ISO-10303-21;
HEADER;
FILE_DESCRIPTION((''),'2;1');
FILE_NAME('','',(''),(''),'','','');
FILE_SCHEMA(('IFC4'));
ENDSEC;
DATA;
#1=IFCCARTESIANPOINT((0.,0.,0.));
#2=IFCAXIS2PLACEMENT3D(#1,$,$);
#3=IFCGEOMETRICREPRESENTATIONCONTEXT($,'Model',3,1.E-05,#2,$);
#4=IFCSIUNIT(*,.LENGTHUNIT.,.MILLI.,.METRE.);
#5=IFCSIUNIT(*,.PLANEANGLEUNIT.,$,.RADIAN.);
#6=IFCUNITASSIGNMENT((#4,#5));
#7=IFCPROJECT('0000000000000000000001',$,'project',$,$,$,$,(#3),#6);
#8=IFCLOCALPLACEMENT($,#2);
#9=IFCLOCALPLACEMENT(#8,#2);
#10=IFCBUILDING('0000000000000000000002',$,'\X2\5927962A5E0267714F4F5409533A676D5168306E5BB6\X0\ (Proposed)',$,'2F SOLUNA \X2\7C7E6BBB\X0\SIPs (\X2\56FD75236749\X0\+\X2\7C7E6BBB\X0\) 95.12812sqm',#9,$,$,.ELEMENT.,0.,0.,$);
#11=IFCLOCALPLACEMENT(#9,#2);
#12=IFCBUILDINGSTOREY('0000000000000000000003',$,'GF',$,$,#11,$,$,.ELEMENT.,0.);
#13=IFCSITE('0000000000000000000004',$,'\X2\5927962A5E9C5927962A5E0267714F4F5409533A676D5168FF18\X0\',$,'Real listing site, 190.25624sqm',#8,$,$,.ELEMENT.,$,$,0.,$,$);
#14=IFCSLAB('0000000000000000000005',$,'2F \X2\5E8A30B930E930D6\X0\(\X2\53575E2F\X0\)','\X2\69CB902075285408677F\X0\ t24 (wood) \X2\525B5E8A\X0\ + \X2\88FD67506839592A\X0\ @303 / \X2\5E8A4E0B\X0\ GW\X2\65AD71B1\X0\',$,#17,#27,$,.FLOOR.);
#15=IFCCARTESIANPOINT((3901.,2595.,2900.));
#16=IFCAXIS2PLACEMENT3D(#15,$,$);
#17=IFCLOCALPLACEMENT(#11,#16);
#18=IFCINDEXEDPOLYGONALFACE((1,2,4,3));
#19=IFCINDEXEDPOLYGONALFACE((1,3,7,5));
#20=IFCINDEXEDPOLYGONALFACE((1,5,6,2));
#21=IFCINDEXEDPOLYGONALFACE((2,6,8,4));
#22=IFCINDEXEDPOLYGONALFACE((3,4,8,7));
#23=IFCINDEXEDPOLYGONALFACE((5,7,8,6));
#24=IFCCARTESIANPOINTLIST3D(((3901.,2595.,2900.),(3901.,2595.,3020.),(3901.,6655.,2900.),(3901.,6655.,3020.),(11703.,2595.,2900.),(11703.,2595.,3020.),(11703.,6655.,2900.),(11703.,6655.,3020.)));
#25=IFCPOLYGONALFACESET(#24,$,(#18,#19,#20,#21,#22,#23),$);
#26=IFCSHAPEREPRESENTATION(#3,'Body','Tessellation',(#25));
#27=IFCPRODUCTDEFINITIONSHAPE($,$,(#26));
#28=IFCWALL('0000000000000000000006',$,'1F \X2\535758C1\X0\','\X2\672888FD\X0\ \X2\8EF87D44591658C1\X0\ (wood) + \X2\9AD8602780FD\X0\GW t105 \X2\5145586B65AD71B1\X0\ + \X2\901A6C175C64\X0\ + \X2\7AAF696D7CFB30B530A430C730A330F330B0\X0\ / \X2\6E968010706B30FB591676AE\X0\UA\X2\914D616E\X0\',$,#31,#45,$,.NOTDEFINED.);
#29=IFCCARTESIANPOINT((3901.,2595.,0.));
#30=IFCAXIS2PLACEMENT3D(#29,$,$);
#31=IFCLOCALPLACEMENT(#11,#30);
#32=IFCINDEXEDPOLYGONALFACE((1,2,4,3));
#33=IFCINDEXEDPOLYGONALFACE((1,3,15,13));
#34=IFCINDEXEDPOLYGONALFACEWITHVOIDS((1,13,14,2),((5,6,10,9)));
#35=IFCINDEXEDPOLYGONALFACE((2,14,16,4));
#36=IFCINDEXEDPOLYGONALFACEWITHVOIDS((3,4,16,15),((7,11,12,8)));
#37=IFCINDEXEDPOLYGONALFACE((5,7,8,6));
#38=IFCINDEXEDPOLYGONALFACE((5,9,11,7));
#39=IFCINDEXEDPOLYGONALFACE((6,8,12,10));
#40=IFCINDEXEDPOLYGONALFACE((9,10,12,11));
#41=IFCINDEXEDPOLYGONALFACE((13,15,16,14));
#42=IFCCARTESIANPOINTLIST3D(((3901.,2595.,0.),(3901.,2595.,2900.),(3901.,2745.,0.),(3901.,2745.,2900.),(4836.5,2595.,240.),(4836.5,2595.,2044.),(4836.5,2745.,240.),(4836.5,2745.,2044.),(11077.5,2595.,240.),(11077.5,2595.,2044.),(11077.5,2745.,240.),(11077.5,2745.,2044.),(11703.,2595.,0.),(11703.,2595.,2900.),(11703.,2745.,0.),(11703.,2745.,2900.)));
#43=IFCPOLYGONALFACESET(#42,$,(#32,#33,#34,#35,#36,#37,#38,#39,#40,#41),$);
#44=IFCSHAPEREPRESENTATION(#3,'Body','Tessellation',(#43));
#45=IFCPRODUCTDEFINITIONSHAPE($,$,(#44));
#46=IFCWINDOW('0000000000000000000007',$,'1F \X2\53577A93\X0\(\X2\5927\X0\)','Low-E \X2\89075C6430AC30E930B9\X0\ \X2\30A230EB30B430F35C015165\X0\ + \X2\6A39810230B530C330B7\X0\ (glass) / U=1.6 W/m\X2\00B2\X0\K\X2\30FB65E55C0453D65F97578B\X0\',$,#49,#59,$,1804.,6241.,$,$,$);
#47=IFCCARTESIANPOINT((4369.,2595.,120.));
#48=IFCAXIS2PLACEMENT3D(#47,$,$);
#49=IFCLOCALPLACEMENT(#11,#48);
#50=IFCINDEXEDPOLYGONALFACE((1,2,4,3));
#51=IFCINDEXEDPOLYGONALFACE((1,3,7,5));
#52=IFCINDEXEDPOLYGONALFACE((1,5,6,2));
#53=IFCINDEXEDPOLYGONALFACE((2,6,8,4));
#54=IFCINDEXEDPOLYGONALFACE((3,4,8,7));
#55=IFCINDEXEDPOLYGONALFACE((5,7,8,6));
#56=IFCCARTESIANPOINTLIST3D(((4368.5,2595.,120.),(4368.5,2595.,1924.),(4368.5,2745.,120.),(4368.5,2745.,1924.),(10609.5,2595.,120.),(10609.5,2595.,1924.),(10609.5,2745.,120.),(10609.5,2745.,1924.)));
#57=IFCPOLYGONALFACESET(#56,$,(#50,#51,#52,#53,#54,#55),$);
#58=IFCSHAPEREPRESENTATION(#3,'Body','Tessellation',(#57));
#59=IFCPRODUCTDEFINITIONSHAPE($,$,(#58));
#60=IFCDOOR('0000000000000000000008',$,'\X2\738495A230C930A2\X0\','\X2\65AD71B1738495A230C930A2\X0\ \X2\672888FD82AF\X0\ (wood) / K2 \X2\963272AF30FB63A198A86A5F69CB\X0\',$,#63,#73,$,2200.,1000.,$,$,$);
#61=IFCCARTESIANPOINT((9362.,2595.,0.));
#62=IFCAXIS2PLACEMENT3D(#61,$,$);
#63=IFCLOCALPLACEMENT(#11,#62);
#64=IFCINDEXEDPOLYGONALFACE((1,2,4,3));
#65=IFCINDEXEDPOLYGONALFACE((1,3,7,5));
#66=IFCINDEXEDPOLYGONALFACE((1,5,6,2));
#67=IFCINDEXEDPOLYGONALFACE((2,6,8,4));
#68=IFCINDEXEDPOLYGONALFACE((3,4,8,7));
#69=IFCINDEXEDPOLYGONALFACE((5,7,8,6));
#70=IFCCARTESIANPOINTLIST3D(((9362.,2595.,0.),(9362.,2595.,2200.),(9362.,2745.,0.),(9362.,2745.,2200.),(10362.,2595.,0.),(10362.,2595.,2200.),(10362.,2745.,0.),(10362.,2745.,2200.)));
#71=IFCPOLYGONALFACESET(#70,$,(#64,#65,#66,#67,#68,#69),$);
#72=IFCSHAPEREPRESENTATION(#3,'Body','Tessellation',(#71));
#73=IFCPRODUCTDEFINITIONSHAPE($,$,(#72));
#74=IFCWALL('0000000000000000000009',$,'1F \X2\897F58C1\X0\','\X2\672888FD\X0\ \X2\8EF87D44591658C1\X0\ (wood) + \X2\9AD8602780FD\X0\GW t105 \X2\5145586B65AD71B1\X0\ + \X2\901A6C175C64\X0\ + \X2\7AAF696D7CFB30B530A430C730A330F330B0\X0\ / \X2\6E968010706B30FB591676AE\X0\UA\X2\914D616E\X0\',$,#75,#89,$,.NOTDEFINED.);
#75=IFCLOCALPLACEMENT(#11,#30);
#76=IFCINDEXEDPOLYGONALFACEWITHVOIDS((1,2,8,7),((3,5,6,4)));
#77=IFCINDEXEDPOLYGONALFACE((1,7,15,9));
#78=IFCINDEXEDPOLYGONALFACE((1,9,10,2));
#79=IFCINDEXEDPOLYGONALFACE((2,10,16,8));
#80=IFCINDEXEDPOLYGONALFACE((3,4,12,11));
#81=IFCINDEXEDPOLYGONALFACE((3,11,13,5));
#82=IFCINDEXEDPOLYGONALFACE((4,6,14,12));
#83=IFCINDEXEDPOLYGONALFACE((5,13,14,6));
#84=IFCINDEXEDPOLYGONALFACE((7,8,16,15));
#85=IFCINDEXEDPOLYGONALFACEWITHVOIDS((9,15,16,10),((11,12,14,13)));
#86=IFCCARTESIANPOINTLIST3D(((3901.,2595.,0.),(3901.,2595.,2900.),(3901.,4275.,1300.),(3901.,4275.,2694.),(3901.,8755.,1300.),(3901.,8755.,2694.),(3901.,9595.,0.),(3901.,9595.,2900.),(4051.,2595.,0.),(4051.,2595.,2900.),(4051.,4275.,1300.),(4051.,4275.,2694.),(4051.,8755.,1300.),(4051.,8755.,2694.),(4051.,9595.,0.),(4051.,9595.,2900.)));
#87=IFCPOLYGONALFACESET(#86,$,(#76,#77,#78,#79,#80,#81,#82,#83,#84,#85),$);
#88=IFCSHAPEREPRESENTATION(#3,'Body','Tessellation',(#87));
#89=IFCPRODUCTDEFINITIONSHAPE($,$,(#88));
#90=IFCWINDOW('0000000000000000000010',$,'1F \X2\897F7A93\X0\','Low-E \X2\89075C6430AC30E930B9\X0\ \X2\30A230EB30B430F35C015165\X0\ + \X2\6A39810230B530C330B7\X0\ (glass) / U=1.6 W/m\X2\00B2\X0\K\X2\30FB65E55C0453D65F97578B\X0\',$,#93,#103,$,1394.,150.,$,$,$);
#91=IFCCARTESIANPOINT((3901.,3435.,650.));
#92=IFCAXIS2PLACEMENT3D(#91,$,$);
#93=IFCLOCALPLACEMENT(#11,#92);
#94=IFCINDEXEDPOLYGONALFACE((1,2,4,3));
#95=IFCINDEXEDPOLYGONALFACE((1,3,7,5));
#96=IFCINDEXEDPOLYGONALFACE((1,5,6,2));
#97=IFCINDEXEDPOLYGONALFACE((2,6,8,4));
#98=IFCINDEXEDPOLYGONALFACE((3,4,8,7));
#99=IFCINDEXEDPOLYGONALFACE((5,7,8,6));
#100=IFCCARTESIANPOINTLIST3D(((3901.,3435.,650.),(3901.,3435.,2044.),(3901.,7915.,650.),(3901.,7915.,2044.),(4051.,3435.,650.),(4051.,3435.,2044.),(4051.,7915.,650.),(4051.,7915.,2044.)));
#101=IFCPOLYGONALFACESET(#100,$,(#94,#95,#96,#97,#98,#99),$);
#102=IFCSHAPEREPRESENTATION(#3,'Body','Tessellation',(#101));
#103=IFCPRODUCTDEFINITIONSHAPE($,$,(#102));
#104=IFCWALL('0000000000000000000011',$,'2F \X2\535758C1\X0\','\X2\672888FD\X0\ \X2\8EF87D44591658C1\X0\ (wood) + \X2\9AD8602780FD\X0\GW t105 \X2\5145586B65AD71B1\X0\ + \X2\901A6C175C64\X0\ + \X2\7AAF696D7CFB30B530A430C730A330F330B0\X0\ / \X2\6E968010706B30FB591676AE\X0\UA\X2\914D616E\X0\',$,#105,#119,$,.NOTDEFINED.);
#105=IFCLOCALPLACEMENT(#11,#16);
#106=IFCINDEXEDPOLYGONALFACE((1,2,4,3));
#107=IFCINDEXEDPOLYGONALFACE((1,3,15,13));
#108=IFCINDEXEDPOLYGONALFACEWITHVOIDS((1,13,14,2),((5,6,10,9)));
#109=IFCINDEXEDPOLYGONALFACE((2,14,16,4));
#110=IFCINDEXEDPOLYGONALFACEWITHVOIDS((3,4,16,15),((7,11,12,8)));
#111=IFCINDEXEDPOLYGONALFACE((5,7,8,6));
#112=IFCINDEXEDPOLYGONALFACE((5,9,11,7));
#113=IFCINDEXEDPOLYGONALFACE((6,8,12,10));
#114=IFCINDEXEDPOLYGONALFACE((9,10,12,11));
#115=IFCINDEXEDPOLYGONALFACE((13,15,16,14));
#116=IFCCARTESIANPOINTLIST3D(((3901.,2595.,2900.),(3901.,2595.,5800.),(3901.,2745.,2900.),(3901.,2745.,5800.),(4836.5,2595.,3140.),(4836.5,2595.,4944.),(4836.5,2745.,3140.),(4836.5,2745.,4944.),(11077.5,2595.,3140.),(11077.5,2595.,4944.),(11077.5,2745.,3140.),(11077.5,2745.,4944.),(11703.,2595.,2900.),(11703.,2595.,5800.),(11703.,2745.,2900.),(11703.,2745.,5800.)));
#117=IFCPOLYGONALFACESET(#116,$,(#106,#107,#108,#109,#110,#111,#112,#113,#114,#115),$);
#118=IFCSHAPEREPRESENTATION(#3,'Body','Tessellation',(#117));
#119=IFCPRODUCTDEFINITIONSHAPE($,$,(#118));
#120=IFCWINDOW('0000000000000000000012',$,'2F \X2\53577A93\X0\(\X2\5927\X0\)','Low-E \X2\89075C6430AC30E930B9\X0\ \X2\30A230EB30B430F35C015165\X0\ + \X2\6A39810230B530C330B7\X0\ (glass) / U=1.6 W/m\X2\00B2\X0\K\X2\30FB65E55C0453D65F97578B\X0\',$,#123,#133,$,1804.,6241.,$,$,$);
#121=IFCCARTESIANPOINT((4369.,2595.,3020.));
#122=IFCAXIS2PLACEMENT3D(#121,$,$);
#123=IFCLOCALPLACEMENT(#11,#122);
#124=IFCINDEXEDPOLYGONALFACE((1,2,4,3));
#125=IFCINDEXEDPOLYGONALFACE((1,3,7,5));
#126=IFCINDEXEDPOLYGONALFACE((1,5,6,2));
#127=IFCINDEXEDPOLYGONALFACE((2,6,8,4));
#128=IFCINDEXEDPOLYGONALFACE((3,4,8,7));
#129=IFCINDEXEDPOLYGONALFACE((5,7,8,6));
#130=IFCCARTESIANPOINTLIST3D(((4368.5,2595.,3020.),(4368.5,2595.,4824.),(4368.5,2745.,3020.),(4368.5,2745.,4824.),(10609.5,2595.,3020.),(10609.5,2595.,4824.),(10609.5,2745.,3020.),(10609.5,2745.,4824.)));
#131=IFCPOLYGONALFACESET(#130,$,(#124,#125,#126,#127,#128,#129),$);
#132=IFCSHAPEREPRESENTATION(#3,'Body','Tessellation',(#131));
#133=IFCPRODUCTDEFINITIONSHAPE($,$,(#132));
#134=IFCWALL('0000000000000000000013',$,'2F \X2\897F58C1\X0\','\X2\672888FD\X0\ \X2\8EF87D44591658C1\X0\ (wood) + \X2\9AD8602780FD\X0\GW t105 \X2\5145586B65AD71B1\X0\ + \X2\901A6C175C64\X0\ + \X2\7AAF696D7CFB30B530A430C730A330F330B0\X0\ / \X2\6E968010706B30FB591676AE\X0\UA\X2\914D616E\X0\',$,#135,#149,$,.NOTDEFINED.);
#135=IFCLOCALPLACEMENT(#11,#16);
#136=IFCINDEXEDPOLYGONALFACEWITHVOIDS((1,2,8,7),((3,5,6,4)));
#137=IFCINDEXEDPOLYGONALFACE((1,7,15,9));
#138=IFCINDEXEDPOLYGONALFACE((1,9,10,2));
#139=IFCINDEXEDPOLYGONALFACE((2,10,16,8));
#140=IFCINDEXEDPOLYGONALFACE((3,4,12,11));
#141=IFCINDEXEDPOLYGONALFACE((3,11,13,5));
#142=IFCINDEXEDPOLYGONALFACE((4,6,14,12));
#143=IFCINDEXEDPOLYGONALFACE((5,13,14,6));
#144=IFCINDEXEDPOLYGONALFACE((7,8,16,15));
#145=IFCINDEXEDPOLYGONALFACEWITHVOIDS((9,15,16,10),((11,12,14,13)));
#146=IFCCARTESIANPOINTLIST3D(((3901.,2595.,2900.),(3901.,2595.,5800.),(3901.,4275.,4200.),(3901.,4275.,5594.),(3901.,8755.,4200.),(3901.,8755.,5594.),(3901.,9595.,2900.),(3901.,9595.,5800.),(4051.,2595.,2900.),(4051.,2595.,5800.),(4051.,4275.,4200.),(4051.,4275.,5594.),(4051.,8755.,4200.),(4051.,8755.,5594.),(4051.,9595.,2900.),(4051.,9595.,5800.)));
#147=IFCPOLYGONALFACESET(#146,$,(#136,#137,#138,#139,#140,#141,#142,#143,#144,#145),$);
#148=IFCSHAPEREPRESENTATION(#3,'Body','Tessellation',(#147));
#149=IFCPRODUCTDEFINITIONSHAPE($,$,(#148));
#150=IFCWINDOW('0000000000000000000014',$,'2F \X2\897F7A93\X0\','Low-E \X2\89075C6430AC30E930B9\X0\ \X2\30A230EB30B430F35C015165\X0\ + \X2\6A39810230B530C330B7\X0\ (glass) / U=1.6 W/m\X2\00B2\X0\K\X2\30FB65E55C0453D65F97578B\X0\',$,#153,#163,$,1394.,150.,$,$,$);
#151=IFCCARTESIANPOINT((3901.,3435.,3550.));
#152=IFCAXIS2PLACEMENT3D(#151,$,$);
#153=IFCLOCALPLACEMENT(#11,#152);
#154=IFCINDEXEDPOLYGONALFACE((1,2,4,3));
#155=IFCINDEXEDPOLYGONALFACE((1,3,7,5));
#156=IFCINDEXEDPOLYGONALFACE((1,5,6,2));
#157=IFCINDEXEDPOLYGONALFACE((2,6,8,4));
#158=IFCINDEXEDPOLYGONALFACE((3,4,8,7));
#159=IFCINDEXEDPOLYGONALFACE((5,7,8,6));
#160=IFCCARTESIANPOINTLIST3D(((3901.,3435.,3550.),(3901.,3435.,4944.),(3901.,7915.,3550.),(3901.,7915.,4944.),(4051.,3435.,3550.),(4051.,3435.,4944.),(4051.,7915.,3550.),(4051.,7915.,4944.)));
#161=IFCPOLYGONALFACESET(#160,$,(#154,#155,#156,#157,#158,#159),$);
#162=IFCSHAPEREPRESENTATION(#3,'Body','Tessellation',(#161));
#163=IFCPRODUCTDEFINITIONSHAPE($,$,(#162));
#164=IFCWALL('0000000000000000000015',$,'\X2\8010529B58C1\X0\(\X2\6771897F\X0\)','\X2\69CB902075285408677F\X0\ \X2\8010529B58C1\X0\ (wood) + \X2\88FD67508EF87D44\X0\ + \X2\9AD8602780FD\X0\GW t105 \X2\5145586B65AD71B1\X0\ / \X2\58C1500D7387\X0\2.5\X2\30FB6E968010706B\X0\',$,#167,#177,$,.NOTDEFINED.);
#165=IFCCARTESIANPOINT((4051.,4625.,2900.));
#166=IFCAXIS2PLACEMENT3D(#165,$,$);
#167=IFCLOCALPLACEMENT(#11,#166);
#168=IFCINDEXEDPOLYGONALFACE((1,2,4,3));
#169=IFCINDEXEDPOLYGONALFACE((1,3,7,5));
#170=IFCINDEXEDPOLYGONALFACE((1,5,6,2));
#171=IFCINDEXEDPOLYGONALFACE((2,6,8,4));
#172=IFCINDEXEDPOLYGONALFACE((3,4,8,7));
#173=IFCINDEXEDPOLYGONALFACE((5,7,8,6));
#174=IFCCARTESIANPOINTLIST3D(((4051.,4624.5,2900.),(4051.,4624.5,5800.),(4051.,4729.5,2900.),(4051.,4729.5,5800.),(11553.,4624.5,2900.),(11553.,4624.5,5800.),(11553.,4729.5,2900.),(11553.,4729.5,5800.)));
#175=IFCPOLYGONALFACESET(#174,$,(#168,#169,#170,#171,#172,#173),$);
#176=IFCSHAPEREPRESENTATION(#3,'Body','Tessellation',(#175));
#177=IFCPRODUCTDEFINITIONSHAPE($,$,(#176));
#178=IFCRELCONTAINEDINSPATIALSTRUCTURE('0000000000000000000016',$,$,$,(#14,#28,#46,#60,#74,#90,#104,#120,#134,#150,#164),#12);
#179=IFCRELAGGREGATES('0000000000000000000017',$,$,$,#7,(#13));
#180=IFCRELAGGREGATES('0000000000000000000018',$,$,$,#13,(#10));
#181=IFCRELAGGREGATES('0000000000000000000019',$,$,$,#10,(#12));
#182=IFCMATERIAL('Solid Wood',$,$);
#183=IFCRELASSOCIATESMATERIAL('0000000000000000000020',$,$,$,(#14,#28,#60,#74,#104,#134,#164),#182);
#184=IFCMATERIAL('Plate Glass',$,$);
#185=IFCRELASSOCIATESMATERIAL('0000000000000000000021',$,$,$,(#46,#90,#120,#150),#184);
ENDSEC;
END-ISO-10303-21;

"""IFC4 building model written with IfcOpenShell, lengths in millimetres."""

from ifc_helpers import new_model, si_unit, frame, frame_2d, origin, place, context, project, spatial, rectangle, extrude, material, element, fill, save


model = new_model("IFC4")

# Units and contexts
model_context = context("Model", 3, precision=1e-05, world=origin())
ifc_project = project(units=[si_unit("LENGTHUNIT", "METRE", prefix="MILLI"), si_unit("PLANEANGLEUNIT", "RADIAN")], contexts=[model_context])

# Site, building, storey
site_placement = place(None, origin())
site = spatial("IfcSite", under=ifc_project, at=site_placement, Name="大阪府大阪市東住吉区杭全８", ObjectType="Real listing site, 190.25624sqm", CompositionType="ELEMENT", RefElevation=0.0)
building_placement = place(site_placement, origin())
building = spatial("IfcBuilding", under=site, at=building_placement, Name="大阪市東住吉区杭全の家 (Proposed)", ObjectType="2F SOLUNA 籾殻SIPs (国産杉+籾殻) 95.12812sqm", CompositionType="ELEMENT", ElevationOfRefHeight=0.0, ElevationOfTerrain=0.0)
storey_placement = place(building_placement, origin())
storey = spatial("IfcBuildingStorey", under=building, at=storey_placement, Name="GF", CompositionType="ELEMENT", Elevation=0.0)

# Slab
ifc_material_1 = material(Name="Solid Wood")
slab_1_placement = place(storey_placement, frame((3901.0, 2595.0, 2900.0)))
element("IfcSlab", 1, at=slab_1_placement, inside=storey, material=ifc_material_1, Name="2F 床スラブ(南帯)", Description="構造用合板 t24 (wood) 剛床 + 製材根太 @303 / 床下 GW断熱", PredefinedType="FLOOR", context=model_context, shape_type="SweptSolid", body=[
    extrude(rectangle(XDim=7802.0, YDim=4060.0, at=frame_2d((3901.0, 2030.0))), frame((3901.0, 2595.0, 2900.0)), (0.0, 0.0, 1.0), 120.0),
])

# Wall, openings, window, door
wall_1_placement = place(storey_placement, frame((3901.0, 2595.0, 0.0)))
wall_1 = element("IfcWall", 2, at=wall_1_placement, inside=storey, material=ifc_material_1, Name="1F 南壁", Description="木製 軸組外壁 (wood) + 高性能GW t105 充填断熱 + 通気層 + 窯業系サイディング / 準耐火・外皮UA配慮", PredefinedType="NOTDEFINED", context=model_context, shape_type="SweptSolid", body=[
    extrude(rectangle(XDim=7802.0, YDim=150.0, at=frame_2d((3901.0, 75.0))), frame((3901.0, 2595.0, 0.0)), (0.0, 0.0, 1.0), 2900.0),
])
opening_1_placement = place(storey_placement, frame((4369.0, 2595.0, 120.0)))
opening_1 = element("IfcOpeningElement", 3, at=opening_1_placement, cuts=wall_1, PredefinedType="NOTDEFINED", context=model_context, shape_type="SweptSolid", body=[
    extrude(rectangle(XDim=6241.0, YDim=150.0, at=frame_2d((3120.0, 75.0))), frame((4369.0, 2595.0, 120.0)), (0.0, 0.0, 1.0), 1804.0),
])
opening_2_placement = place(storey_placement, frame((9362.0, 2595.0, 0.0)))
opening_2 = element("IfcOpeningElement", 4, at=opening_2_placement, cuts=wall_1, PredefinedType="NOTDEFINED", context=model_context, shape_type="SweptSolid", body=[
    extrude(rectangle(XDim=1000.0, YDim=150.0, at=frame_2d((500.0, 75.0))), frame((9362.0, 2595.0, 0.0)), (0.0, 0.0, 1.0), 2200.0),
])
ifc_material_2 = material(Name="Plate Glass")
window_1_placement = place(storey_placement, frame((4369.0, 2595.0, 120.0)))
window_1 = element("IfcWindow", 5, at=window_1_placement, inside=storey, material=ifc_material_2, Name="1F 南窓(大)", Description="Low-E 複層ガラス アルゴン封入 + 樹脂サッシ (glass) / U=1.6 W/m²K・日射取得型", OverallHeight=1804.0, OverallWidth=6241.0, context=model_context, shape_type="SweptSolid", body=[
    extrude(rectangle(XDim=6241.0, YDim=150.0, at=frame_2d((3120.0, 75.0))), frame((4369.0, 2595.0, 120.0)), (0.0, 0.0, 1.0), 1804.0),
])
fill(opening_1, window_1)
door_placement = place(storey_placement, frame((9362.0, 2595.0, 0.0)))
door = element("IfcDoor", 6, at=door_placement, inside=storey, material=ifc_material_1, Name="玄関ドア", Description="断熱玄関ドア 木製芯 (wood) / K2 防犯・採風機構", OverallHeight=2200.0, OverallWidth=1000.0, context=model_context, shape_type="SweptSolid", body=[
    extrude(rectangle(XDim=1000.0, YDim=150.0, at=frame_2d((500.0, 75.0))), frame((9362.0, 2595.0, 0.0)), (0.0, 0.0, 1.0), 2200.0),
])
fill(opening_2, door)

# Wall, opening, window
wall_2_placement = place(storey_placement, frame((3901.0, 2595.0, 0.0)))
wall_2 = element("IfcWall", 7, at=wall_2_placement, inside=storey, material=ifc_material_1, Name="1F 西壁", Description="木製 軸組外壁 (wood) + 高性能GW t105 充填断熱 + 通気層 + 窯業系サイディング / 準耐火・外皮UA配慮", PredefinedType="NOTDEFINED", context=model_context, shape_type="SweptSolid", body=[
    extrude(rectangle(XDim=150.0, YDim=7000.0, at=frame_2d((75.0, 3500.0))), frame((3901.0, 2595.0, 0.0)), (0.0, 0.0, 1.0), 2900.0),
])
opening_3_placement = place(storey_placement, frame((3901.0, 3435.0, 650.0)))
opening_3 = element("IfcOpeningElement", 8, at=opening_3_placement, cuts=wall_2, PredefinedType="NOTDEFINED", context=model_context, shape_type="SweptSolid", body=[
    extrude(rectangle(XDim=150.0, YDim=4480.0, at=frame_2d((75.0, 2240.0))), frame((3901.0, 3435.0, 650.0)), (0.0, 0.0, 1.0), 1394.0),
])
window_2_placement = place(storey_placement, frame((3901.0, 3435.0, 650.0)))
window_2 = element("IfcWindow", 9, at=window_2_placement, inside=storey, material=ifc_material_2, Name="1F 西窓", Description="Low-E 複層ガラス アルゴン封入 + 樹脂サッシ (glass) / U=1.6 W/m²K・日射取得型", OverallHeight=1394.0, OverallWidth=150.0, context=model_context, shape_type="SweptSolid", body=[
    extrude(rectangle(XDim=150.0, YDim=4480.0, at=frame_2d((75.0, 2240.0))), frame((3901.0, 3435.0, 650.0)), (0.0, 0.0, 1.0), 1394.0),
])
fill(opening_3, window_2)

# Walls, openings, windows
wall_3_placement = place(storey_placement, frame((3901.0, 2595.0, 2900.0)))
wall_3 = element("IfcWall", 10, at=wall_3_placement, inside=storey, material=ifc_material_1, Name="2F 南壁", Description="木製 軸組外壁 (wood) + 高性能GW t105 充填断熱 + 通気層 + 窯業系サイディング / 準耐火・外皮UA配慮", PredefinedType="NOTDEFINED", context=model_context, shape_type="SweptSolid", body=[
    extrude(rectangle(XDim=7802.0, YDim=150.0, at=frame_2d((3901.0, 75.0))), frame((3901.0, 2595.0, 2900.0)), (0.0, 0.0, 1.0), 2900.0),
])
opening_4_placement = place(storey_placement, frame((4369.0, 2595.0, 3020.0)))
opening_4 = element("IfcOpeningElement", 11, at=opening_4_placement, cuts=wall_3, PredefinedType="NOTDEFINED", context=model_context, shape_type="SweptSolid", body=[
    extrude(rectangle(XDim=6241.0, YDim=150.0, at=frame_2d((3120.0, 75.0))), frame((4369.0, 2595.0, 3020.0)), (0.0, 0.0, 1.0), 1804.0),
])
window_3_placement = place(storey_placement, frame((4369.0, 2595.0, 3020.0)))
window_3 = element("IfcWindow", 12, at=window_3_placement, inside=storey, material=ifc_material_2, Name="2F 南窓(大)", Description="Low-E 複層ガラス アルゴン封入 + 樹脂サッシ (glass) / U=1.6 W/m²K・日射取得型", OverallHeight=1804.0, OverallWidth=6241.0, context=model_context, shape_type="SweptSolid", body=[
    extrude(rectangle(XDim=6241.0, YDim=150.0, at=frame_2d((3120.0, 75.0))), frame((4369.0, 2595.0, 3020.0)), (0.0, 0.0, 1.0), 1804.0),
])
fill(opening_4, window_3)
wall_4_placement = place(storey_placement, frame((3901.0, 2595.0, 2900.0)))
wall_4 = element("IfcWall", 13, at=wall_4_placement, inside=storey, material=ifc_material_1, Name="2F 西壁", Description="木製 軸組外壁 (wood) + 高性能GW t105 充填断熱 + 通気層 + 窯業系サイディング / 準耐火・外皮UA配慮", PredefinedType="NOTDEFINED", context=model_context, shape_type="SweptSolid", body=[
    extrude(rectangle(XDim=150.0, YDim=7000.0, at=frame_2d((75.0, 3500.0))), frame((3901.0, 2595.0, 2900.0)), (0.0, 0.0, 1.0), 2900.0),
])
opening_5_placement = place(storey_placement, frame((3901.0, 3435.0, 3550.0)))
opening_5 = element("IfcOpeningElement", 14, at=opening_5_placement, cuts=wall_4, PredefinedType="NOTDEFINED", context=model_context, shape_type="SweptSolid", body=[
    extrude(rectangle(XDim=150.0, YDim=4480.0, at=frame_2d((75.0, 2240.0))), frame((3901.0, 3435.0, 3550.0)), (0.0, 0.0, 1.0), 1394.0),
])
window_4_placement = place(storey_placement, frame((3901.0, 3435.0, 3550.0)))
window_4 = element("IfcWindow", 15, at=window_4_placement, inside=storey, material=ifc_material_2, Name="2F 西窓", Description="Low-E 複層ガラス アルゴン封入 + 樹脂サッシ (glass) / U=1.6 W/m²K・日射取得型", OverallHeight=1394.0, OverallWidth=150.0, context=model_context, shape_type="SweptSolid", body=[
    extrude(rectangle(XDim=150.0, YDim=4480.0, at=frame_2d((75.0, 2240.0))), frame((3901.0, 3435.0, 3550.0)), (0.0, 0.0, 1.0), 1394.0),
])
fill(opening_5, window_4)

# Wall
wall_5_placement = place(storey_placement, frame((4051.0, 4625.0, 2900.0)))
element("IfcWall", 16, at=wall_5_placement, inside=storey, material=ifc_material_1, Name="耐力壁(東西)", Description="構造用合板 耐力壁 (wood) + 製材軸組 + 高性能GW t105 充填断熱 / 壁倍率2.5・準耐火", PredefinedType="NOTDEFINED", context=model_context, shape_type="SweptSolid", body=[
    extrude(rectangle(XDim=7502.0, YDim=105.0, at=frame_2d((3751.0, 52.0))), frame((4051.0, 4625.0, 2900.0)), (0.0, 0.0, 1.0), 2900.0),
])

save(model, "model.ifc")
